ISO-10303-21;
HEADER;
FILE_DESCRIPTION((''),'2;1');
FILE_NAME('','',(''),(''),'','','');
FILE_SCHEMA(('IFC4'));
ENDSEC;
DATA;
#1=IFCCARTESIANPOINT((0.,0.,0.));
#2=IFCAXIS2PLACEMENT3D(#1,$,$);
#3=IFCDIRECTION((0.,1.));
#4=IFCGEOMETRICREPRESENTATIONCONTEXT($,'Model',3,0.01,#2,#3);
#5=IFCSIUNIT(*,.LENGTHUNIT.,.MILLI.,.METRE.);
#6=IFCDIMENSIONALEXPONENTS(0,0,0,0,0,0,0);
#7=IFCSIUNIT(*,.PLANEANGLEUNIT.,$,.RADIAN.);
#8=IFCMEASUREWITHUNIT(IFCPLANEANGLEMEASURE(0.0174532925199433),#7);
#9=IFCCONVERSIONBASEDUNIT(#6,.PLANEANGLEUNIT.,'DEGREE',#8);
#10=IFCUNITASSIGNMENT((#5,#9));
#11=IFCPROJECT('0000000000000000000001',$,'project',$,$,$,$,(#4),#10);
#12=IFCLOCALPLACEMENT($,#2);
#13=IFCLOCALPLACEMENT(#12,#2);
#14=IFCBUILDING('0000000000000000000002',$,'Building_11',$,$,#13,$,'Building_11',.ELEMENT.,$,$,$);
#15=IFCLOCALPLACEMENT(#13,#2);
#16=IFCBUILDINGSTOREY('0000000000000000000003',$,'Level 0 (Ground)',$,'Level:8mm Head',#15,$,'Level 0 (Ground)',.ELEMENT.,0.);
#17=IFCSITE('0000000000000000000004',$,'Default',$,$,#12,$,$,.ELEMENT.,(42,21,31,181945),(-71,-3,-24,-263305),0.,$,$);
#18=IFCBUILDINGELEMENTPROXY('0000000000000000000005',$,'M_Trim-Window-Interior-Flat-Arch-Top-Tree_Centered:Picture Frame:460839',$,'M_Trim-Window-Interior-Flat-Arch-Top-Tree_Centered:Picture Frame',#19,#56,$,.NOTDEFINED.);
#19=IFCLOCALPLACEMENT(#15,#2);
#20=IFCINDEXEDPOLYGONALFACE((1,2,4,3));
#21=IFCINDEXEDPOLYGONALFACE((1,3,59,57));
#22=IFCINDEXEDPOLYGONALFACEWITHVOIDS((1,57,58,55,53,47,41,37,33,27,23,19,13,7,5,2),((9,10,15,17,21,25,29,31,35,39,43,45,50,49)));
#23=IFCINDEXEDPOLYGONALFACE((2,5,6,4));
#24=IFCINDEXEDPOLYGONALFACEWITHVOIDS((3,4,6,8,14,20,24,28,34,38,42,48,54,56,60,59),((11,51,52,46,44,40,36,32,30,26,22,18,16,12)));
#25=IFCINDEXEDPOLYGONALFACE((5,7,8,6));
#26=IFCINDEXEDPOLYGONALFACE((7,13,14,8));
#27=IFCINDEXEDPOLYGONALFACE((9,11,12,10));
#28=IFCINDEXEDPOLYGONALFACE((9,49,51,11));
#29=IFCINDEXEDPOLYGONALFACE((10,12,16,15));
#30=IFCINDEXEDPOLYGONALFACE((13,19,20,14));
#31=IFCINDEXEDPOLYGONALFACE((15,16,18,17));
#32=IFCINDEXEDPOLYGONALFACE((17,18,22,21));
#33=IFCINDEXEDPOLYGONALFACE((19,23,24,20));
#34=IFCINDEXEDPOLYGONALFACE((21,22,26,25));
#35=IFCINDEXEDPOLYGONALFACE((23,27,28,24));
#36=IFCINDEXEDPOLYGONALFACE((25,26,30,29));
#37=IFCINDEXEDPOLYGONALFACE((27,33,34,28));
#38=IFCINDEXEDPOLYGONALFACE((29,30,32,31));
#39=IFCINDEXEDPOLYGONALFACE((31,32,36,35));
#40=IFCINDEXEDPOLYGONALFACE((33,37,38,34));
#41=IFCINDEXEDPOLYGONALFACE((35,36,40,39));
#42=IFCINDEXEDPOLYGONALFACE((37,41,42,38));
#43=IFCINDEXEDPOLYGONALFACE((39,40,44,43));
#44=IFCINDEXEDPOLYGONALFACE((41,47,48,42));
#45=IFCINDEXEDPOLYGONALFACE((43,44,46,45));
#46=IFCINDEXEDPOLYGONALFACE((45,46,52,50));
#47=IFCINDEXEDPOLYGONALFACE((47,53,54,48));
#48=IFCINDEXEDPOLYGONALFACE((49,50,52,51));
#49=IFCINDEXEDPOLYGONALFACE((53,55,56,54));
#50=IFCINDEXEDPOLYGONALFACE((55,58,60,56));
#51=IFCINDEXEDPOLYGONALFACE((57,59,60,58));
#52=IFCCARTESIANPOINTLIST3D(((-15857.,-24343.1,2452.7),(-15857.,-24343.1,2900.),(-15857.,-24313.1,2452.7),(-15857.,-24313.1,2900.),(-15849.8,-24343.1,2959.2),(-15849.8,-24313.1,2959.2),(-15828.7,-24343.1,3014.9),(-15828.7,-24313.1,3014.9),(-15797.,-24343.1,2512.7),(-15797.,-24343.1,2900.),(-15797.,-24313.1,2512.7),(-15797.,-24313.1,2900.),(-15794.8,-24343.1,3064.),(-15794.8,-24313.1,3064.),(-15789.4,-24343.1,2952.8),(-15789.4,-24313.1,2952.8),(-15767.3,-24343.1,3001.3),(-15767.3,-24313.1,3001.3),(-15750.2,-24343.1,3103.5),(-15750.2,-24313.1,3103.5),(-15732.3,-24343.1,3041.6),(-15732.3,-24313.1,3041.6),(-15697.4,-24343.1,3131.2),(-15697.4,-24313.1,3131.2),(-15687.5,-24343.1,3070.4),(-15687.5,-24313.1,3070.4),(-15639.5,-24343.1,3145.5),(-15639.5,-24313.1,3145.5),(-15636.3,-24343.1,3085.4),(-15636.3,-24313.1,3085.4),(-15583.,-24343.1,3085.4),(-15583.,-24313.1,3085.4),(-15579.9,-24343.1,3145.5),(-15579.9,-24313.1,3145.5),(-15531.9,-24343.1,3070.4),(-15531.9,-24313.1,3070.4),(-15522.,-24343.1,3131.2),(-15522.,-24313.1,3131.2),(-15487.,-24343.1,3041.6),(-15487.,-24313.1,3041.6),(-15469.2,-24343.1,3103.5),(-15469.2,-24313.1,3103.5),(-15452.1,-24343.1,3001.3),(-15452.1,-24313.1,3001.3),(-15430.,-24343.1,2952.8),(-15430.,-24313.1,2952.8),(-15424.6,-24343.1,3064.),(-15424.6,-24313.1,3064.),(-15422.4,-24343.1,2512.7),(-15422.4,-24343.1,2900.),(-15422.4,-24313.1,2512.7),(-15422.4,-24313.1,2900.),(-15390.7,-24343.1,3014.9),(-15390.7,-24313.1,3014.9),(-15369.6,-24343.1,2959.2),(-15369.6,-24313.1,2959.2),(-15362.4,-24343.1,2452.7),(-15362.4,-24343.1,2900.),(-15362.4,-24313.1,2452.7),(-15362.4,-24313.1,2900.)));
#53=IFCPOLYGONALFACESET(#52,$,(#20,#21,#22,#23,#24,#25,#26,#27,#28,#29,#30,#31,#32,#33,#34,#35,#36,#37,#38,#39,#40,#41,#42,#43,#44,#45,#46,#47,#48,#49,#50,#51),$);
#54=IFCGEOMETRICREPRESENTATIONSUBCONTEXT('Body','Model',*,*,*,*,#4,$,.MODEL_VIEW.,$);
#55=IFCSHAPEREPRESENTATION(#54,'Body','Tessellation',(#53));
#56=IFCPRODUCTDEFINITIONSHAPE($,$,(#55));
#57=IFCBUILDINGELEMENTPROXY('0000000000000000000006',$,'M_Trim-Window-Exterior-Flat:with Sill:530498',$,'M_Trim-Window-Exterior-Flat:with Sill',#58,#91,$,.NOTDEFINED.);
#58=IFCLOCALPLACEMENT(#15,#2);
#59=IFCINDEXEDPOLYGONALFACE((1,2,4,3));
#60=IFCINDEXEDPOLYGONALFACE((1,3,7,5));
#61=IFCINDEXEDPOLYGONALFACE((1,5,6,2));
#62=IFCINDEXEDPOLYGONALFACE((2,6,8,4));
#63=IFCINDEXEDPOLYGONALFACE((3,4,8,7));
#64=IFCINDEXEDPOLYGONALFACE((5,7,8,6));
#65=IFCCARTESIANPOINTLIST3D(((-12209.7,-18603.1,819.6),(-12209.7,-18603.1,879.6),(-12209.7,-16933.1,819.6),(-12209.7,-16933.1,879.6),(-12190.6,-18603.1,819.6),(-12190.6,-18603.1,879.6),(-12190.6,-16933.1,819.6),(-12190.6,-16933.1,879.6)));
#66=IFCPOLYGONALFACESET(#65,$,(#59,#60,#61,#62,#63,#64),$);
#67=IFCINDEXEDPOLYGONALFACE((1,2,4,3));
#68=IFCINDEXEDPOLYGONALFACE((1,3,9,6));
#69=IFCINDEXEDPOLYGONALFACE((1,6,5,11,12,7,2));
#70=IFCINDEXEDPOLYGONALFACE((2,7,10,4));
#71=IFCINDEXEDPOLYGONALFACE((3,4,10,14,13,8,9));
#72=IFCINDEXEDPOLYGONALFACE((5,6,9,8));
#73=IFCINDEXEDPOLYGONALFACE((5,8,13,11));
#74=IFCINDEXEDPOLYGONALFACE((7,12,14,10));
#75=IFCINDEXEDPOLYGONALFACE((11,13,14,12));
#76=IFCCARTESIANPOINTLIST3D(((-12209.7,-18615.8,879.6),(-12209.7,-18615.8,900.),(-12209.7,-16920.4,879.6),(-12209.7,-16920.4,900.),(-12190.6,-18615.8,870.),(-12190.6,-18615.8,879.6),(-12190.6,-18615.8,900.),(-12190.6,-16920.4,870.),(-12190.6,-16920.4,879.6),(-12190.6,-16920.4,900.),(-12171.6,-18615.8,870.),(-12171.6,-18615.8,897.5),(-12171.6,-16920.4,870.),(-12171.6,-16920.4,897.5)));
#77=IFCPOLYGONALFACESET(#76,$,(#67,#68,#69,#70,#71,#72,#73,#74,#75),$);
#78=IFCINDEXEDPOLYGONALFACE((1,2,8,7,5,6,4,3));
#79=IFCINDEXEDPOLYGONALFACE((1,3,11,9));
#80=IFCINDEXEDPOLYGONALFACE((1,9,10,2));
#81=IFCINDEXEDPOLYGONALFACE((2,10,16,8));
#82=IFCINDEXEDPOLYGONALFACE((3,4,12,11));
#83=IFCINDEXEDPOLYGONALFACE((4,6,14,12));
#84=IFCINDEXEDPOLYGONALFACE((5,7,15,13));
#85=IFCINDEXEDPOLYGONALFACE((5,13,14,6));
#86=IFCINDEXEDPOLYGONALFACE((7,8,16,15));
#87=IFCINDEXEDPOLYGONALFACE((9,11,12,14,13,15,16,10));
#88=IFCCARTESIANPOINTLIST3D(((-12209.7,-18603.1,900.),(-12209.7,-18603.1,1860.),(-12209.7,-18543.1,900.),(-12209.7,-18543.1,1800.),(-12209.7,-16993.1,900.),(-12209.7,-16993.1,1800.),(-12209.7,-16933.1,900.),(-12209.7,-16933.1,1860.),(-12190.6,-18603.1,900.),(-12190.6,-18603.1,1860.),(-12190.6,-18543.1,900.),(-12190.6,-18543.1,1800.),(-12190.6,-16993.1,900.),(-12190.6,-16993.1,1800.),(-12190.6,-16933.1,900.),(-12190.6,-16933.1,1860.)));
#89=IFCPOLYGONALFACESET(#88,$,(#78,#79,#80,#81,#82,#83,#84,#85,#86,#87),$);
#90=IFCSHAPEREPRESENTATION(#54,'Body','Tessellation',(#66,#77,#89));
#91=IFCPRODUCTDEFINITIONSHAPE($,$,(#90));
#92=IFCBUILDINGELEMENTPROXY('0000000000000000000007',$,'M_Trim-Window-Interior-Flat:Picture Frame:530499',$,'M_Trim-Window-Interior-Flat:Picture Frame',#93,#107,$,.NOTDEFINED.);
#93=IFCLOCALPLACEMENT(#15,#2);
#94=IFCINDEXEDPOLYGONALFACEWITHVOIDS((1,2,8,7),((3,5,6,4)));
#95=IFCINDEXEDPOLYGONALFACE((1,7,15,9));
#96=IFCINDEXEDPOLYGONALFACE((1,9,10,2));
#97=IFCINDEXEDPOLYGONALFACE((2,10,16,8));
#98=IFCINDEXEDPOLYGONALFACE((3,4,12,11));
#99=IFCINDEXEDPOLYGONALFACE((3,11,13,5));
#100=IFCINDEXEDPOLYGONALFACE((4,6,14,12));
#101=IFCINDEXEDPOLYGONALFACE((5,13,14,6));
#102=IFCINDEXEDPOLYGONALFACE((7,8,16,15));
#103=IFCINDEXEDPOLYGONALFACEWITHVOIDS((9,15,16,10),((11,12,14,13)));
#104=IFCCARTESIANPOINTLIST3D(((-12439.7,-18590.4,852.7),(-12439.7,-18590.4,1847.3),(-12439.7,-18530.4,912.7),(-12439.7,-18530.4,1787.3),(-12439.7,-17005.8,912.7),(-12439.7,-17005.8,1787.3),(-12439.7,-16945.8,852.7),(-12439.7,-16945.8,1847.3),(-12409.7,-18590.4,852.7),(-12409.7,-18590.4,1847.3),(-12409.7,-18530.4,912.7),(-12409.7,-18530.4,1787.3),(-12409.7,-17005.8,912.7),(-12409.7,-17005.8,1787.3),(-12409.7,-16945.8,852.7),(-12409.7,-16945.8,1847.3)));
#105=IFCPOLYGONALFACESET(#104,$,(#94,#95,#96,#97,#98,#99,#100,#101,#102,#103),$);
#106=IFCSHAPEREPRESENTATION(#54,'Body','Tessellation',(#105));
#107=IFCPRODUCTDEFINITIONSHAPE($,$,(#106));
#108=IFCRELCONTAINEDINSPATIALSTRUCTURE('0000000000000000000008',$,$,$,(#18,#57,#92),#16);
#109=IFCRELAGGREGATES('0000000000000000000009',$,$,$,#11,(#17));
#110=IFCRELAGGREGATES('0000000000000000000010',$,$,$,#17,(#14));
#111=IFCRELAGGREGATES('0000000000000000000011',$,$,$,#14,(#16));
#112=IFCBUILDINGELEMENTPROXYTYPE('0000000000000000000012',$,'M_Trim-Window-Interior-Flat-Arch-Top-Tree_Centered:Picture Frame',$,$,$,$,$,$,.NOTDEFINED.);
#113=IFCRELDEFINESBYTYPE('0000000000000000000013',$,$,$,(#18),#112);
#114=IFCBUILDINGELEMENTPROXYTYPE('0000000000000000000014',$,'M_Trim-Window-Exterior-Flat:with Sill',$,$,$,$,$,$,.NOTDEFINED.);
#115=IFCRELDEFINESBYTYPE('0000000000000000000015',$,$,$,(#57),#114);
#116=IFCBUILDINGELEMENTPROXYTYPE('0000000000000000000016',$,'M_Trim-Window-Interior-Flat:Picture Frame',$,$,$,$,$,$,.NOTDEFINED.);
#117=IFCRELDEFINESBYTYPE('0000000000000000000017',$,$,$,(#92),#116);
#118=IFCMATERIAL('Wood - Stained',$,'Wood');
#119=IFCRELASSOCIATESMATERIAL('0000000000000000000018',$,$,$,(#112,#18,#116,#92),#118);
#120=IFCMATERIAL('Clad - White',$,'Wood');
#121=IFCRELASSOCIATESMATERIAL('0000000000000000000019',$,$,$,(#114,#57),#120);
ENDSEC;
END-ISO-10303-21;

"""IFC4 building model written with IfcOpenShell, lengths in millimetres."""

from ifc_helpers import new_model, entity, si_unit, converted_unit, direction, frame, origin, place, context, subcontext, project, spatial, line, arc, indexed_curve, outline, extrude, source, transform, mapped, material, type_object, type_shapes, element, save


model = new_model("IFC4")

# Units and contexts
model_context = context("Model", 3, precision=0.01, world=origin(), true_north=direction((0.0, 1.0)))
body_context = subcontext(model_context, "Body", "Model", "MODEL_VIEW")
ifc_project = project(units=[si_unit("LENGTHUNIT", "METRE", prefix="MILLI"), converted_unit("PLANEANGLEUNIT", "DEGREE", entity("IfcPlaneAngleMeasure", 0.0174532925199433), si_unit("PLANEANGLEUNIT", "RADIAN"), dimensions=[0, 0, 0, 0, 0, 0, 0])], contexts=[model_context])

# Site, building, storey
site_placement = place(None, origin())
site = spatial("IfcSite", under=ifc_project, at=site_placement, Name="Default", CompositionType="ELEMENT", RefLatitude=(42, 21, 31, 181945), RefLongitude=(-71, -3, -24, -263305), RefElevation=0.0)
building_placement = place(site_placement, origin())
building = spatial("IfcBuilding", under=site, at=building_placement, Name="Building_11", LongName="Building_11", CompositionType="ELEMENT")
storey_placement = place(building_placement, origin())
storey = spatial("IfcBuildingStorey", under=building, at=storey_placement, Name="Level 0 (Ground)", ObjectType="Level:8mm Head", LongName="Level 0 (Ground)", CompositionType="ELEMENT", Elevation=0.0)

# Building element proxies
ifc_material_1 = material(Name="Clad - White", Category="Wood")
ifc_material_2 = material(Name="Wood - Stained", Category="Wood")
building_element_proxy_type_1 = type_object("IfcBuildingElementProxyType", Name="M_Trim-Window-Interior-Flat-Arch-Top-Tree_Centered:Picture Frame", PredefinedType="NOTDEFINED", material=ifc_material_2)
shared_shape_1 = source(origin(), body_context, "Body", "SweptSolid", [
    extrude(outline(indexed_curve([(-223.7, -247.3), (223.7, -247.3), (223.7, 247.3), (-223.7, 247.3), (-470.9, 0.0)], segments=[line(1, 2, 3, 4), arc(4, 5, 1)], self_intersect=False), holes=[indexed_curve([(-223.6, -187.3), (-411.0, 0.0), (-223.7, 187.3), (163.6, 187.3), (163.7, -187.3)], segments=[arc(1, 2, 3), line(3, 4, 5, 1)], self_intersect=False)]), frame((0.0, -423.7, 0.0), z_axis=(0.0, 0.0, 1.0), x_axis=(0.0, -1.0, 0.0)), (0.0, 0.0, 1.0), 30.0),
])
type_shapes(building_element_proxy_type_1, [shared_shape_1])
proxy_1_placement = place(storey_placement, frame((-15609.7, -24343.1, 3100.0), z_axis=(0.0, 1.0, 0.0), x_axis=(-1.0, 0.0, 0.0)))
element("IfcBuildingElementProxy", 1, at=proxy_1_placement, inside=storey, type_object=building_element_proxy_type_1, material=ifc_material_2, Name="M_Trim-Window-Interior-Flat-Arch-Top-Tree_Centered:Picture Frame:460839", ObjectType="M_Trim-Window-Interior-Flat-Arch-Top-Tree_Centered:Picture Frame", PredefinedType="NOTDEFINED", context=body_context, shape_type="MappedRepresentation", body=[
    mapped(shared_shape_1, transform((0.0, 0.0, 0.0), scale=1.0)),
])
building_element_proxy_type_2 = type_object("IfcBuildingElementProxyType", Name="M_Trim-Window-Exterior-Flat:with Sill", PredefinedType="NOTDEFINED", material=ifc_material_1)
shared_shape_2 = source(origin(), body_context, "Body", "SweptSolid", [
    extrude(outline(indexed_curve([(-835.0, -30.0), (835.0, -30.0), (835.0, 30.0), (-835.0, 30.0), (-835.0, -30.0)], self_intersect=False)), frame((0.0, -950.4, 0.0), z_axis=(0.0, 0.0, 1.0), x_axis=(-1.0, 0.0, 0.0)), (0.0, 0.0, 1.0), 19.1),
    extrude(outline(indexed_curve([(-19.0, -15.2), (0.0, -15.2), (0.0, -5.7), (19.0, -5.7), (19.0, 14.8), (0.0, 14.8), (-19.0, 12.3), (-19.0, -15.2)], self_intersect=False)), frame((-847.7, -914.8, 19.0), z_axis=(1.0, 0.0, 0.0), x_axis=(0.0, 0.0, -1.0)), (0.0, 0.0, 1.0), 1695.4),
    extrude(outline(indexed_curve([(-495.0, -835.0), (465.0, -835.0), (465.0, -775.0), (-435.0, -775.0), (-435.0, 775.0), (465.0, 775.0), (465.0, 835.0), (-495.0, 835.0), (-495.0, -835.0)], self_intersect=False)), frame((0.0, -435.0, 0.0), z_axis=(0.0, 0.0, 1.0), x_axis=(0.0, -1.0, 0.0)), (0.0, 0.0, 1.0), 19.1),
])
type_shapes(building_element_proxy_type_2, [shared_shape_2])
proxy_2_placement = place(storey_placement, frame((-12209.7, -17768.1, 1800.0), z_axis=(1.0, 0.0, 0.0), x_axis=(0.0, 1.0, 0.0)))
element("IfcBuildingElementProxy", 2, at=proxy_2_placement, inside=storey, type_object=building_element_proxy_type_2, material=ifc_material_1, Name="M_Trim-Window-Exterior-Flat:with Sill:530498", ObjectType="M_Trim-Window-Exterior-Flat:with Sill", PredefinedType="NOTDEFINED", context=body_context, shape_type="MappedRepresentation", body=[
    mapped(shared_shape_2, transform((0.0, 0.0, 0.0), scale=1.0)),
])
building_element_proxy_type_3 = type_object("IfcBuildingElementProxyType", Name="M_Trim-Window-Interior-Flat:Picture Frame", PredefinedType="NOTDEFINED", material=ifc_material_2)
shared_shape_3 = source(origin(), body_context, "Body", "SweptSolid", [
    extrude(outline(indexed_curve([(-822.3, -497.3), (822.3, -497.3), (822.3, 497.3), (-822.3, 497.3), (-822.3, -497.3)], self_intersect=False), holes=[indexed_curve([(-762.3, -437.3), (-762.3, 437.3), (762.3, 437.3), (762.3, -437.3), (-762.3, -437.3)], self_intersect=False)]), frame((0.0, -450.0, 0.0), z_axis=(0.0, 0.0, 1.0), x_axis=(-1.0, 0.0, 0.0)), (0.0, 0.0, 1.0), 30.0),
])
type_shapes(building_element_proxy_type_3, [shared_shape_3])
proxy_3_placement = place(storey_placement, frame((-12409.7, -17768.1, 1800.0), z_axis=(-1.0, 0.0, 0.0), x_axis=(0.0, -1.0, 0.0)))
element("IfcBuildingElementProxy", 3, at=proxy_3_placement, inside=storey, type_object=building_element_proxy_type_3, material=ifc_material_2, Name="M_Trim-Window-Interior-Flat:Picture Frame:530499", ObjectType="M_Trim-Window-Interior-Flat:Picture Frame", PredefinedType="NOTDEFINED", context=body_context, shape_type="MappedRepresentation", body=[
    mapped(shared_shape_3, transform((0.0, 0.0, 0.0), scale=1.0)),
])

save(model, "model.ifc")
